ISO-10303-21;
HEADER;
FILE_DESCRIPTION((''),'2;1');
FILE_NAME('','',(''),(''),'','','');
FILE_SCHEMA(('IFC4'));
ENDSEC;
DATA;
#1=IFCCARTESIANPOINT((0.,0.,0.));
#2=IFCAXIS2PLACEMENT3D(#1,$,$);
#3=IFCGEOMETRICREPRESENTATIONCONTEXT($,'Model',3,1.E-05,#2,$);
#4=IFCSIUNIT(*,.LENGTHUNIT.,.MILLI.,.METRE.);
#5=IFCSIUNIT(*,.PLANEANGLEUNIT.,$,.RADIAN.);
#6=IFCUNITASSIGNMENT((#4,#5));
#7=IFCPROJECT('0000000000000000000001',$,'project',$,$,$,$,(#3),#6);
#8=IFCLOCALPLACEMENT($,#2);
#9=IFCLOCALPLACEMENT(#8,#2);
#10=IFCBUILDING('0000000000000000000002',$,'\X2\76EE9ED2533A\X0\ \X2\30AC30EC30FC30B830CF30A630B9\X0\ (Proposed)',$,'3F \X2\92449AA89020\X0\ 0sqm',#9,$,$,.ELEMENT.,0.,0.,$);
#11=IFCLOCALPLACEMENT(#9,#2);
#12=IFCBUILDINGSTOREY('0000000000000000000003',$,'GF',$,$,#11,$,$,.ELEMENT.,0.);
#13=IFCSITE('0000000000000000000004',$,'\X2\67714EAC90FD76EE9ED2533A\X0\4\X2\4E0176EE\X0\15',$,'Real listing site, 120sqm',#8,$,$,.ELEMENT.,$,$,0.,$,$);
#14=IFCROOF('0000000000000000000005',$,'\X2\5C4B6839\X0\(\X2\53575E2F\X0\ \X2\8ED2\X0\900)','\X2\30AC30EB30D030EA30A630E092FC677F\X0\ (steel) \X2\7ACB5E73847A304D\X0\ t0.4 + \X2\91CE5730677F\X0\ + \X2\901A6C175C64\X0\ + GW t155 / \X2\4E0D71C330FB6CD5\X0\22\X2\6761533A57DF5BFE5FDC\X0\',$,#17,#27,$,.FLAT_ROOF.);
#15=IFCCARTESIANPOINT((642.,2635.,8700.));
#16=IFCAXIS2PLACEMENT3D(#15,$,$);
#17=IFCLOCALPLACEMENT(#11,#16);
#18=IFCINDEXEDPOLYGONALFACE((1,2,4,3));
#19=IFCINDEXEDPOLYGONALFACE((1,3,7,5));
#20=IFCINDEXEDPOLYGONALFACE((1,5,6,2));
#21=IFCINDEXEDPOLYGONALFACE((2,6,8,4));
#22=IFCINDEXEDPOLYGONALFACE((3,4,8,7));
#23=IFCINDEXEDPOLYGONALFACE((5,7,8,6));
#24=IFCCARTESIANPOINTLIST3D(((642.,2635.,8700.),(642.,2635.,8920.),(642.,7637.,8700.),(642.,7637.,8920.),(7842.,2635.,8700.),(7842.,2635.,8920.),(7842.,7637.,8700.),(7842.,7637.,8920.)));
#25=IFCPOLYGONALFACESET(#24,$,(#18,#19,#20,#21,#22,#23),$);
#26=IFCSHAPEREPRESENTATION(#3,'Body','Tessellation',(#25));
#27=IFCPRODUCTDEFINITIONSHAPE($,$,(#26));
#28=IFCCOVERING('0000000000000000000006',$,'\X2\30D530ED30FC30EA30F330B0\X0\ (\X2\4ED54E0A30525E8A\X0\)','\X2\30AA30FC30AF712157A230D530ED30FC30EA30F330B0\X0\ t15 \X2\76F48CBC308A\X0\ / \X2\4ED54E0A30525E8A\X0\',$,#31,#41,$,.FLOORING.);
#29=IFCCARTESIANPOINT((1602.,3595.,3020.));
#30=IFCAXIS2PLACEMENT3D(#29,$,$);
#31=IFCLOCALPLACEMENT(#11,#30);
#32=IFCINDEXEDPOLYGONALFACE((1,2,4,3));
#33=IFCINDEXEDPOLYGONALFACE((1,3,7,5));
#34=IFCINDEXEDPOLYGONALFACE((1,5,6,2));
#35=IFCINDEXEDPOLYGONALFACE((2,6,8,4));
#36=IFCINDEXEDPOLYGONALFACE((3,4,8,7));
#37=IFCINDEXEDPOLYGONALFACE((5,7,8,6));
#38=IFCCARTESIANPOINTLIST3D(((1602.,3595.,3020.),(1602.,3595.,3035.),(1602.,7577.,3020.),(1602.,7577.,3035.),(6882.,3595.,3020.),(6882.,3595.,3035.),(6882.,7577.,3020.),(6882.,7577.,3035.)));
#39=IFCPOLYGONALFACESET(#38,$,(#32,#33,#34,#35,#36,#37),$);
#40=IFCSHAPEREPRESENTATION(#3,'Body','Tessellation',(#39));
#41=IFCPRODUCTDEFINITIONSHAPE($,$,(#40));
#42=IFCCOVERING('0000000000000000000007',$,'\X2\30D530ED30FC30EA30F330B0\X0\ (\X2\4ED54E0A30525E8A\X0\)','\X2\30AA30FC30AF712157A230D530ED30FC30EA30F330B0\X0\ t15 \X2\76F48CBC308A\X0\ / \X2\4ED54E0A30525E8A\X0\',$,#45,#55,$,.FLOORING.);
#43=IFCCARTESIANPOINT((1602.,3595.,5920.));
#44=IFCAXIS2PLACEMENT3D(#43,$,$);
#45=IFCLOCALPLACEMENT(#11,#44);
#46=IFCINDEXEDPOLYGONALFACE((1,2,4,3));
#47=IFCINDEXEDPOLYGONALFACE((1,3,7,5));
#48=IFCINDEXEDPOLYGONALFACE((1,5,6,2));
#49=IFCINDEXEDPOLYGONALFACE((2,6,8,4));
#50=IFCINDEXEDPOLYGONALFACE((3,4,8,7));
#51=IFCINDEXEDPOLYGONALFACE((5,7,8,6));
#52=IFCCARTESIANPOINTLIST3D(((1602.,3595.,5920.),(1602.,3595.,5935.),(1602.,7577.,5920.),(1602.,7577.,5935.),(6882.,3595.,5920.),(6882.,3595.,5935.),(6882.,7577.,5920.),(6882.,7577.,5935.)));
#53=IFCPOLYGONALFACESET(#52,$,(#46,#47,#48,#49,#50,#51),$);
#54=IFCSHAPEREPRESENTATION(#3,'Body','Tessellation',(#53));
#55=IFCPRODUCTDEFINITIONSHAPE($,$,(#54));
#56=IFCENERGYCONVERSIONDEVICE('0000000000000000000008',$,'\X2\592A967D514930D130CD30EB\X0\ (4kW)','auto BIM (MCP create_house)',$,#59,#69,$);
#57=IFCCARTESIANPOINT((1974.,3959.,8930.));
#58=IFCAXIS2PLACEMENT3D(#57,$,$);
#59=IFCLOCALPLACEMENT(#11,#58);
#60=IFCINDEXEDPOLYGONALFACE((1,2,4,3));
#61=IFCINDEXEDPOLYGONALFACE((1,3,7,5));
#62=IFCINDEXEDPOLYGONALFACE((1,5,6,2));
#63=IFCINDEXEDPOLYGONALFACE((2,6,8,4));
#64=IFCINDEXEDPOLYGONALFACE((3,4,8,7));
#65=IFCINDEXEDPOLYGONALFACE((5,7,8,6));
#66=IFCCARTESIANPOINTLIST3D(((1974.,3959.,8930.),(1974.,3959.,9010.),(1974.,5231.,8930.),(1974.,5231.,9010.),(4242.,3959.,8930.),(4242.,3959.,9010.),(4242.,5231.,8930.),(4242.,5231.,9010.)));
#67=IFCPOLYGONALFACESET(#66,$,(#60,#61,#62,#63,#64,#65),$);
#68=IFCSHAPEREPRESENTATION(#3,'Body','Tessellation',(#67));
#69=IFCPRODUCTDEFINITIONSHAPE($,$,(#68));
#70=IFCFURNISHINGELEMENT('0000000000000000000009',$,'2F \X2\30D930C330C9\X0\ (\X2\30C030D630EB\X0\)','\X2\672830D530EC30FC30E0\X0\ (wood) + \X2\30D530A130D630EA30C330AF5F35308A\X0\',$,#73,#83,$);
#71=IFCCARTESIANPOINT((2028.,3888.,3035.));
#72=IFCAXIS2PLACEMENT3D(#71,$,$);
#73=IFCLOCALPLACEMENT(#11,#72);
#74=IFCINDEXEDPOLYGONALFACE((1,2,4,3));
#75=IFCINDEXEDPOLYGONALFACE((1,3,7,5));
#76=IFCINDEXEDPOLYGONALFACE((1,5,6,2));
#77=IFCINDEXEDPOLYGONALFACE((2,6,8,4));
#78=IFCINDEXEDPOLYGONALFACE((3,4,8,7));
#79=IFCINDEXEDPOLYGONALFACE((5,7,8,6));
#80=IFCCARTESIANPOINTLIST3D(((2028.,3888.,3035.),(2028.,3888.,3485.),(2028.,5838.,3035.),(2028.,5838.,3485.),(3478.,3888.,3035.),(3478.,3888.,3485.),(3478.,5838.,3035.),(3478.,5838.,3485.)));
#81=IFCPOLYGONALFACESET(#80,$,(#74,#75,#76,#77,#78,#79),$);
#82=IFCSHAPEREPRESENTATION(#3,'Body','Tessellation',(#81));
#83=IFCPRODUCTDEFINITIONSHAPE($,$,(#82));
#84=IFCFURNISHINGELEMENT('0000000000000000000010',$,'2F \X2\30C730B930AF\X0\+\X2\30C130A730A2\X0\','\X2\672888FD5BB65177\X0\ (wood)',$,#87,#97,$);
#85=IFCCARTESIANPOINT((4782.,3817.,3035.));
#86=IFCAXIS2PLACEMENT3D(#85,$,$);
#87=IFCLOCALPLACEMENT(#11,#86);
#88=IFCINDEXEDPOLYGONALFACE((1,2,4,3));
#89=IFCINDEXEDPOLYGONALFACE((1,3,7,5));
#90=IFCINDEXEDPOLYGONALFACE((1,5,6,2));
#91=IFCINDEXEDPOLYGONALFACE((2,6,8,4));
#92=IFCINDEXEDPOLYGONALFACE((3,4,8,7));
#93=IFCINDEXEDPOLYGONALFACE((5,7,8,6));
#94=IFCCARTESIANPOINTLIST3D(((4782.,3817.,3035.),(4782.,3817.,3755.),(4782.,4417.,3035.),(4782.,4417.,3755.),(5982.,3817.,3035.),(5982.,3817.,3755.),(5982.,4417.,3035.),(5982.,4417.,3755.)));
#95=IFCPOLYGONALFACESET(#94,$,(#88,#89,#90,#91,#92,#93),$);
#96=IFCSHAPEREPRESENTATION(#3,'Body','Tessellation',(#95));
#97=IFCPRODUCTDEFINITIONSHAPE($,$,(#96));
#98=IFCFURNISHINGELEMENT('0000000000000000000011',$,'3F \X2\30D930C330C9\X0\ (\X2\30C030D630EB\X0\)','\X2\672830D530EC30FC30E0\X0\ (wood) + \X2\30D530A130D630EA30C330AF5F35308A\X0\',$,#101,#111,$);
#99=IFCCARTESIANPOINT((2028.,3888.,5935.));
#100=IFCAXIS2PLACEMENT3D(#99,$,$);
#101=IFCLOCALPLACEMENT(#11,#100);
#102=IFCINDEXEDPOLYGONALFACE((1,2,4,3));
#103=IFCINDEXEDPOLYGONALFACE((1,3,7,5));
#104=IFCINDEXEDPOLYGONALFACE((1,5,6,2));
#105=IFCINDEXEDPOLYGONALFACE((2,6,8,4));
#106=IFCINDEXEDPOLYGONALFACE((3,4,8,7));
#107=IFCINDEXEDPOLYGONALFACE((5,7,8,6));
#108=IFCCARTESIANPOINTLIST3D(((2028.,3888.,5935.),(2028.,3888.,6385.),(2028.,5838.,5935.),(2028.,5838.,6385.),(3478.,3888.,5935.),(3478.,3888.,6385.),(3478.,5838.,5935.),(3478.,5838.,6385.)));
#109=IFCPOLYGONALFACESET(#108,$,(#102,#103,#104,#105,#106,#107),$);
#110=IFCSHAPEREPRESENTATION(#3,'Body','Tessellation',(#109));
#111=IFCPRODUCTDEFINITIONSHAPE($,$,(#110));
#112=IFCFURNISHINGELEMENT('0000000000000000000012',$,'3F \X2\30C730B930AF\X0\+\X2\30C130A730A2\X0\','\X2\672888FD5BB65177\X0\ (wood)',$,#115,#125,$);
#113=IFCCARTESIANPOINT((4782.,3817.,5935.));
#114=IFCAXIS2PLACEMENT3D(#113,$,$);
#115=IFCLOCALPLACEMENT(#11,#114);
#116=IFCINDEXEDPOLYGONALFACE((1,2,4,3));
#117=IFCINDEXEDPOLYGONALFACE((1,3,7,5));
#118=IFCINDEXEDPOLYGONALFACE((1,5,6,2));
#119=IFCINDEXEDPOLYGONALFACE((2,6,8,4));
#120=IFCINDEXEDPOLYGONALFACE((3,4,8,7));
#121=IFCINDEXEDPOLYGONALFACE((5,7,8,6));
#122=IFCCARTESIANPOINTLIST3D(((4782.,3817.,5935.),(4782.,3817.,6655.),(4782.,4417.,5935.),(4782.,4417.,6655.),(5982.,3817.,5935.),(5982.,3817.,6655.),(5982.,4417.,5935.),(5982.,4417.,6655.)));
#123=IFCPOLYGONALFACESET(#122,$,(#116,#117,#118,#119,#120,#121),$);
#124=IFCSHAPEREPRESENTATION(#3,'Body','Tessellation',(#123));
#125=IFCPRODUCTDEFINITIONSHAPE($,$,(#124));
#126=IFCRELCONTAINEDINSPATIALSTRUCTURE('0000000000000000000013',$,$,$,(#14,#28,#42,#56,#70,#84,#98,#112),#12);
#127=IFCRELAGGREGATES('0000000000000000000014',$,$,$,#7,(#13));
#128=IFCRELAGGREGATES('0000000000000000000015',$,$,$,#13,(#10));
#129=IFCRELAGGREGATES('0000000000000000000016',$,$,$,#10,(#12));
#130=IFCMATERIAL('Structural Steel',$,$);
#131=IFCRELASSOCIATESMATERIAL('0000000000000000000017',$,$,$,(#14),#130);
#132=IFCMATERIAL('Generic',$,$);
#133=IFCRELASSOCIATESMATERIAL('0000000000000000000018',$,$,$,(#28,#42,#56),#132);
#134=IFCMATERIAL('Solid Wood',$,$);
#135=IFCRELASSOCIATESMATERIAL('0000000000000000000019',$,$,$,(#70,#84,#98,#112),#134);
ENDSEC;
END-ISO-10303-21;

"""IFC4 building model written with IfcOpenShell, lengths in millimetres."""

from ifc_helpers import new_model, si_unit, frame, frame_2d, origin, place, context, project, spatial, rectangle, extrude, material, element, save


model = new_model("IFC4")

# Units and contexts
model_context = context("Model", 3, precision=1e-05, world=origin())
ifc_project = project(units=[si_unit("LENGTHUNIT", "METRE", prefix="MILLI"), si_unit("PLANEANGLEUNIT", "RADIAN")], contexts=[model_context])

# Site, building, storey
site_placement = place(None, origin())
site = spatial("IfcSite", under=ifc_project, at=site_placement, Name="東京都目黒区4丁目15", ObjectType="Real listing site, 120sqm", CompositionType="ELEMENT", RefElevation=0.0)
building_placement = place(site_placement, origin())
building = spatial("IfcBuilding", under=site, at=building_placement, Name="目黒区 ガレージハウス (Proposed)", ObjectType="3F 鉄骨造 0sqm", CompositionType="ELEMENT", ElevationOfRefHeight=0.0, ElevationOfTerrain=0.0)
storey_placement = place(building_placement, origin())
storey = spatial("IfcBuildingStorey", under=building, at=storey_placement, Name="GF", CompositionType="ELEMENT", Elevation=0.0)

# Shared definitions
ifc_material_1 = material(Name="Solid Wood")

# Roof
ifc_material_2 = material(Name="Structural Steel")
for number, where, name in (
    (1, (642.0, 2635.0, 8700.0), "屋根(南帯 軒900)"),
):
    element("IfcRoof", number, at=place(storey_placement, frame(where)), inside=storey, material=ifc_material_2, Name=name, Description="ガルバリウム鋼板 (steel) 立平葺き t0.4 + 野地板 + 通気層 + GW t155 / 不燃・法22条区域対応", PredefinedType="FLAT_ROOF", context=model_context, shape_type="SweptSolid", body=[
        extrude(rectangle(XDim=7200.0, YDim=5002.0, at=frame_2d((3600.0, 2501.0))), frame((642.0, 2635.0, 8700.0)), (0.0, 0.0, 1.0), 220.0),
    ])

# Coverings
ifc_material_3 = material(Name="Generic")
covering_1_placement = place(storey_placement, frame((1602.0, 3595.0, 3020.0)))
element("IfcCovering", 2, at=covering_1_placement, inside=storey, material=ifc_material_3, Name="フローリング (仕上げ床)", Description="オーク無垢フローリング t15 直貼り / 仕上げ床", PredefinedType="FLOORING", context=model_context, shape_type="SweptSolid", body=[
    extrude(rectangle(XDim=5280.0, YDim=3982.0, at=frame_2d((2640.0, 1991.0))), frame((1602.0, 3595.0, 3020.0)), (0.0, 0.0, 1.0), 15.0),
])
covering_2_placement = place(storey_placement, frame((1602.0, 3595.0, 5920.0)))
element("IfcCovering", 3, at=covering_2_placement, inside=storey, material=ifc_material_3, Name="フローリング (仕上げ床)", Description="オーク無垢フローリング t15 直貼り / 仕上げ床", PredefinedType="FLOORING", context=model_context, shape_type="SweptSolid", body=[
    extrude(rectangle(XDim=5280.0, YDim=3982.0, at=frame_2d((2640.0, 1991.0))), frame((1602.0, 3595.0, 5920.0)), (0.0, 0.0, 1.0), 15.0),
])

# Energy conversion device
energy_conversion_device_placement = place(storey_placement, frame((1974.0, 3959.0, 8930.0)))
element("IfcEnergyConversionDevice", 4, at=energy_conversion_device_placement, inside=storey, material=ifc_material_3, Name="太陽光パネル (4kW)", Description="auto BIM (MCP create_house)", context=model_context, shape_type="SweptSolid", body=[
    extrude(rectangle(XDim=2268.0, YDim=1272.0, at=frame_2d((1134.0, 636.0))), frame((1974.0, 3959.0, 8930.0)), (0.0, 0.0, 1.0), 80.0),
])

# Furnishing elements
furnishing_1_placement = place(storey_placement, frame((2028.0, 3888.0, 3035.0)))
element("IfcFurnishingElement", 5, at=furnishing_1_placement, inside=storey, material=ifc_material_1, Name="2F ベッド (ダブル)", Description="木フレーム (wood) + ファブリック張り", context=model_context, shape_type="SweptSolid", body=[
    extrude(rectangle(XDim=1450.0, YDim=1950.0, at=frame_2d((725.0, 975.0))), frame((2028.0, 3888.0, 3035.0)), (0.0, 0.0, 1.0), 450.0),
])
furnishing_2_placement = place(storey_placement, frame((4782.0, 3817.0, 3035.0)))
element("IfcFurnishingElement", 6, at=furnishing_2_placement, inside=storey, material=ifc_material_1, Name="2F デスク+チェア", Description="木製家具 (wood)", context=model_context, shape_type="SweptSolid", body=[
    extrude(rectangle(XDim=1200.0, YDim=600.0, at=frame_2d((600.0, 300.0))), frame((4782.0, 3817.0, 3035.0)), (0.0, 0.0, 1.0), 720.0),
])
furnishing_3_placement = place(storey_placement, frame((2028.0, 3888.0, 5935.0)))
element("IfcFurnishingElement", 7, at=furnishing_3_placement, inside=storey, material=ifc_material_1, Name="3F ベッド (ダブル)", Description="木フレーム (wood) + ファブリック張り", context=model_context, shape_type="SweptSolid", body=[
    extrude(rectangle(XDim=1450.0, YDim=1950.0, at=frame_2d((725.0, 975.0))), frame((2028.0, 3888.0, 5935.0)), (0.0, 0.0, 1.0), 450.0),
])
furnishing_4_placement = place(storey_placement, frame((4782.0, 3817.0, 5935.0)))
element("IfcFurnishingElement", 8, at=furnishing_4_placement, inside=storey, material=ifc_material_1, Name="3F デスク+チェア", Description="木製家具 (wood)", context=model_context, shape_type="SweptSolid", body=[
    extrude(rectangle(XDim=1200.0, YDim=600.0, at=frame_2d((600.0, 300.0))), frame((4782.0, 3817.0, 5935.0)), (0.0, 0.0, 1.0), 720.0),
])

save(model, "model.ifc")
